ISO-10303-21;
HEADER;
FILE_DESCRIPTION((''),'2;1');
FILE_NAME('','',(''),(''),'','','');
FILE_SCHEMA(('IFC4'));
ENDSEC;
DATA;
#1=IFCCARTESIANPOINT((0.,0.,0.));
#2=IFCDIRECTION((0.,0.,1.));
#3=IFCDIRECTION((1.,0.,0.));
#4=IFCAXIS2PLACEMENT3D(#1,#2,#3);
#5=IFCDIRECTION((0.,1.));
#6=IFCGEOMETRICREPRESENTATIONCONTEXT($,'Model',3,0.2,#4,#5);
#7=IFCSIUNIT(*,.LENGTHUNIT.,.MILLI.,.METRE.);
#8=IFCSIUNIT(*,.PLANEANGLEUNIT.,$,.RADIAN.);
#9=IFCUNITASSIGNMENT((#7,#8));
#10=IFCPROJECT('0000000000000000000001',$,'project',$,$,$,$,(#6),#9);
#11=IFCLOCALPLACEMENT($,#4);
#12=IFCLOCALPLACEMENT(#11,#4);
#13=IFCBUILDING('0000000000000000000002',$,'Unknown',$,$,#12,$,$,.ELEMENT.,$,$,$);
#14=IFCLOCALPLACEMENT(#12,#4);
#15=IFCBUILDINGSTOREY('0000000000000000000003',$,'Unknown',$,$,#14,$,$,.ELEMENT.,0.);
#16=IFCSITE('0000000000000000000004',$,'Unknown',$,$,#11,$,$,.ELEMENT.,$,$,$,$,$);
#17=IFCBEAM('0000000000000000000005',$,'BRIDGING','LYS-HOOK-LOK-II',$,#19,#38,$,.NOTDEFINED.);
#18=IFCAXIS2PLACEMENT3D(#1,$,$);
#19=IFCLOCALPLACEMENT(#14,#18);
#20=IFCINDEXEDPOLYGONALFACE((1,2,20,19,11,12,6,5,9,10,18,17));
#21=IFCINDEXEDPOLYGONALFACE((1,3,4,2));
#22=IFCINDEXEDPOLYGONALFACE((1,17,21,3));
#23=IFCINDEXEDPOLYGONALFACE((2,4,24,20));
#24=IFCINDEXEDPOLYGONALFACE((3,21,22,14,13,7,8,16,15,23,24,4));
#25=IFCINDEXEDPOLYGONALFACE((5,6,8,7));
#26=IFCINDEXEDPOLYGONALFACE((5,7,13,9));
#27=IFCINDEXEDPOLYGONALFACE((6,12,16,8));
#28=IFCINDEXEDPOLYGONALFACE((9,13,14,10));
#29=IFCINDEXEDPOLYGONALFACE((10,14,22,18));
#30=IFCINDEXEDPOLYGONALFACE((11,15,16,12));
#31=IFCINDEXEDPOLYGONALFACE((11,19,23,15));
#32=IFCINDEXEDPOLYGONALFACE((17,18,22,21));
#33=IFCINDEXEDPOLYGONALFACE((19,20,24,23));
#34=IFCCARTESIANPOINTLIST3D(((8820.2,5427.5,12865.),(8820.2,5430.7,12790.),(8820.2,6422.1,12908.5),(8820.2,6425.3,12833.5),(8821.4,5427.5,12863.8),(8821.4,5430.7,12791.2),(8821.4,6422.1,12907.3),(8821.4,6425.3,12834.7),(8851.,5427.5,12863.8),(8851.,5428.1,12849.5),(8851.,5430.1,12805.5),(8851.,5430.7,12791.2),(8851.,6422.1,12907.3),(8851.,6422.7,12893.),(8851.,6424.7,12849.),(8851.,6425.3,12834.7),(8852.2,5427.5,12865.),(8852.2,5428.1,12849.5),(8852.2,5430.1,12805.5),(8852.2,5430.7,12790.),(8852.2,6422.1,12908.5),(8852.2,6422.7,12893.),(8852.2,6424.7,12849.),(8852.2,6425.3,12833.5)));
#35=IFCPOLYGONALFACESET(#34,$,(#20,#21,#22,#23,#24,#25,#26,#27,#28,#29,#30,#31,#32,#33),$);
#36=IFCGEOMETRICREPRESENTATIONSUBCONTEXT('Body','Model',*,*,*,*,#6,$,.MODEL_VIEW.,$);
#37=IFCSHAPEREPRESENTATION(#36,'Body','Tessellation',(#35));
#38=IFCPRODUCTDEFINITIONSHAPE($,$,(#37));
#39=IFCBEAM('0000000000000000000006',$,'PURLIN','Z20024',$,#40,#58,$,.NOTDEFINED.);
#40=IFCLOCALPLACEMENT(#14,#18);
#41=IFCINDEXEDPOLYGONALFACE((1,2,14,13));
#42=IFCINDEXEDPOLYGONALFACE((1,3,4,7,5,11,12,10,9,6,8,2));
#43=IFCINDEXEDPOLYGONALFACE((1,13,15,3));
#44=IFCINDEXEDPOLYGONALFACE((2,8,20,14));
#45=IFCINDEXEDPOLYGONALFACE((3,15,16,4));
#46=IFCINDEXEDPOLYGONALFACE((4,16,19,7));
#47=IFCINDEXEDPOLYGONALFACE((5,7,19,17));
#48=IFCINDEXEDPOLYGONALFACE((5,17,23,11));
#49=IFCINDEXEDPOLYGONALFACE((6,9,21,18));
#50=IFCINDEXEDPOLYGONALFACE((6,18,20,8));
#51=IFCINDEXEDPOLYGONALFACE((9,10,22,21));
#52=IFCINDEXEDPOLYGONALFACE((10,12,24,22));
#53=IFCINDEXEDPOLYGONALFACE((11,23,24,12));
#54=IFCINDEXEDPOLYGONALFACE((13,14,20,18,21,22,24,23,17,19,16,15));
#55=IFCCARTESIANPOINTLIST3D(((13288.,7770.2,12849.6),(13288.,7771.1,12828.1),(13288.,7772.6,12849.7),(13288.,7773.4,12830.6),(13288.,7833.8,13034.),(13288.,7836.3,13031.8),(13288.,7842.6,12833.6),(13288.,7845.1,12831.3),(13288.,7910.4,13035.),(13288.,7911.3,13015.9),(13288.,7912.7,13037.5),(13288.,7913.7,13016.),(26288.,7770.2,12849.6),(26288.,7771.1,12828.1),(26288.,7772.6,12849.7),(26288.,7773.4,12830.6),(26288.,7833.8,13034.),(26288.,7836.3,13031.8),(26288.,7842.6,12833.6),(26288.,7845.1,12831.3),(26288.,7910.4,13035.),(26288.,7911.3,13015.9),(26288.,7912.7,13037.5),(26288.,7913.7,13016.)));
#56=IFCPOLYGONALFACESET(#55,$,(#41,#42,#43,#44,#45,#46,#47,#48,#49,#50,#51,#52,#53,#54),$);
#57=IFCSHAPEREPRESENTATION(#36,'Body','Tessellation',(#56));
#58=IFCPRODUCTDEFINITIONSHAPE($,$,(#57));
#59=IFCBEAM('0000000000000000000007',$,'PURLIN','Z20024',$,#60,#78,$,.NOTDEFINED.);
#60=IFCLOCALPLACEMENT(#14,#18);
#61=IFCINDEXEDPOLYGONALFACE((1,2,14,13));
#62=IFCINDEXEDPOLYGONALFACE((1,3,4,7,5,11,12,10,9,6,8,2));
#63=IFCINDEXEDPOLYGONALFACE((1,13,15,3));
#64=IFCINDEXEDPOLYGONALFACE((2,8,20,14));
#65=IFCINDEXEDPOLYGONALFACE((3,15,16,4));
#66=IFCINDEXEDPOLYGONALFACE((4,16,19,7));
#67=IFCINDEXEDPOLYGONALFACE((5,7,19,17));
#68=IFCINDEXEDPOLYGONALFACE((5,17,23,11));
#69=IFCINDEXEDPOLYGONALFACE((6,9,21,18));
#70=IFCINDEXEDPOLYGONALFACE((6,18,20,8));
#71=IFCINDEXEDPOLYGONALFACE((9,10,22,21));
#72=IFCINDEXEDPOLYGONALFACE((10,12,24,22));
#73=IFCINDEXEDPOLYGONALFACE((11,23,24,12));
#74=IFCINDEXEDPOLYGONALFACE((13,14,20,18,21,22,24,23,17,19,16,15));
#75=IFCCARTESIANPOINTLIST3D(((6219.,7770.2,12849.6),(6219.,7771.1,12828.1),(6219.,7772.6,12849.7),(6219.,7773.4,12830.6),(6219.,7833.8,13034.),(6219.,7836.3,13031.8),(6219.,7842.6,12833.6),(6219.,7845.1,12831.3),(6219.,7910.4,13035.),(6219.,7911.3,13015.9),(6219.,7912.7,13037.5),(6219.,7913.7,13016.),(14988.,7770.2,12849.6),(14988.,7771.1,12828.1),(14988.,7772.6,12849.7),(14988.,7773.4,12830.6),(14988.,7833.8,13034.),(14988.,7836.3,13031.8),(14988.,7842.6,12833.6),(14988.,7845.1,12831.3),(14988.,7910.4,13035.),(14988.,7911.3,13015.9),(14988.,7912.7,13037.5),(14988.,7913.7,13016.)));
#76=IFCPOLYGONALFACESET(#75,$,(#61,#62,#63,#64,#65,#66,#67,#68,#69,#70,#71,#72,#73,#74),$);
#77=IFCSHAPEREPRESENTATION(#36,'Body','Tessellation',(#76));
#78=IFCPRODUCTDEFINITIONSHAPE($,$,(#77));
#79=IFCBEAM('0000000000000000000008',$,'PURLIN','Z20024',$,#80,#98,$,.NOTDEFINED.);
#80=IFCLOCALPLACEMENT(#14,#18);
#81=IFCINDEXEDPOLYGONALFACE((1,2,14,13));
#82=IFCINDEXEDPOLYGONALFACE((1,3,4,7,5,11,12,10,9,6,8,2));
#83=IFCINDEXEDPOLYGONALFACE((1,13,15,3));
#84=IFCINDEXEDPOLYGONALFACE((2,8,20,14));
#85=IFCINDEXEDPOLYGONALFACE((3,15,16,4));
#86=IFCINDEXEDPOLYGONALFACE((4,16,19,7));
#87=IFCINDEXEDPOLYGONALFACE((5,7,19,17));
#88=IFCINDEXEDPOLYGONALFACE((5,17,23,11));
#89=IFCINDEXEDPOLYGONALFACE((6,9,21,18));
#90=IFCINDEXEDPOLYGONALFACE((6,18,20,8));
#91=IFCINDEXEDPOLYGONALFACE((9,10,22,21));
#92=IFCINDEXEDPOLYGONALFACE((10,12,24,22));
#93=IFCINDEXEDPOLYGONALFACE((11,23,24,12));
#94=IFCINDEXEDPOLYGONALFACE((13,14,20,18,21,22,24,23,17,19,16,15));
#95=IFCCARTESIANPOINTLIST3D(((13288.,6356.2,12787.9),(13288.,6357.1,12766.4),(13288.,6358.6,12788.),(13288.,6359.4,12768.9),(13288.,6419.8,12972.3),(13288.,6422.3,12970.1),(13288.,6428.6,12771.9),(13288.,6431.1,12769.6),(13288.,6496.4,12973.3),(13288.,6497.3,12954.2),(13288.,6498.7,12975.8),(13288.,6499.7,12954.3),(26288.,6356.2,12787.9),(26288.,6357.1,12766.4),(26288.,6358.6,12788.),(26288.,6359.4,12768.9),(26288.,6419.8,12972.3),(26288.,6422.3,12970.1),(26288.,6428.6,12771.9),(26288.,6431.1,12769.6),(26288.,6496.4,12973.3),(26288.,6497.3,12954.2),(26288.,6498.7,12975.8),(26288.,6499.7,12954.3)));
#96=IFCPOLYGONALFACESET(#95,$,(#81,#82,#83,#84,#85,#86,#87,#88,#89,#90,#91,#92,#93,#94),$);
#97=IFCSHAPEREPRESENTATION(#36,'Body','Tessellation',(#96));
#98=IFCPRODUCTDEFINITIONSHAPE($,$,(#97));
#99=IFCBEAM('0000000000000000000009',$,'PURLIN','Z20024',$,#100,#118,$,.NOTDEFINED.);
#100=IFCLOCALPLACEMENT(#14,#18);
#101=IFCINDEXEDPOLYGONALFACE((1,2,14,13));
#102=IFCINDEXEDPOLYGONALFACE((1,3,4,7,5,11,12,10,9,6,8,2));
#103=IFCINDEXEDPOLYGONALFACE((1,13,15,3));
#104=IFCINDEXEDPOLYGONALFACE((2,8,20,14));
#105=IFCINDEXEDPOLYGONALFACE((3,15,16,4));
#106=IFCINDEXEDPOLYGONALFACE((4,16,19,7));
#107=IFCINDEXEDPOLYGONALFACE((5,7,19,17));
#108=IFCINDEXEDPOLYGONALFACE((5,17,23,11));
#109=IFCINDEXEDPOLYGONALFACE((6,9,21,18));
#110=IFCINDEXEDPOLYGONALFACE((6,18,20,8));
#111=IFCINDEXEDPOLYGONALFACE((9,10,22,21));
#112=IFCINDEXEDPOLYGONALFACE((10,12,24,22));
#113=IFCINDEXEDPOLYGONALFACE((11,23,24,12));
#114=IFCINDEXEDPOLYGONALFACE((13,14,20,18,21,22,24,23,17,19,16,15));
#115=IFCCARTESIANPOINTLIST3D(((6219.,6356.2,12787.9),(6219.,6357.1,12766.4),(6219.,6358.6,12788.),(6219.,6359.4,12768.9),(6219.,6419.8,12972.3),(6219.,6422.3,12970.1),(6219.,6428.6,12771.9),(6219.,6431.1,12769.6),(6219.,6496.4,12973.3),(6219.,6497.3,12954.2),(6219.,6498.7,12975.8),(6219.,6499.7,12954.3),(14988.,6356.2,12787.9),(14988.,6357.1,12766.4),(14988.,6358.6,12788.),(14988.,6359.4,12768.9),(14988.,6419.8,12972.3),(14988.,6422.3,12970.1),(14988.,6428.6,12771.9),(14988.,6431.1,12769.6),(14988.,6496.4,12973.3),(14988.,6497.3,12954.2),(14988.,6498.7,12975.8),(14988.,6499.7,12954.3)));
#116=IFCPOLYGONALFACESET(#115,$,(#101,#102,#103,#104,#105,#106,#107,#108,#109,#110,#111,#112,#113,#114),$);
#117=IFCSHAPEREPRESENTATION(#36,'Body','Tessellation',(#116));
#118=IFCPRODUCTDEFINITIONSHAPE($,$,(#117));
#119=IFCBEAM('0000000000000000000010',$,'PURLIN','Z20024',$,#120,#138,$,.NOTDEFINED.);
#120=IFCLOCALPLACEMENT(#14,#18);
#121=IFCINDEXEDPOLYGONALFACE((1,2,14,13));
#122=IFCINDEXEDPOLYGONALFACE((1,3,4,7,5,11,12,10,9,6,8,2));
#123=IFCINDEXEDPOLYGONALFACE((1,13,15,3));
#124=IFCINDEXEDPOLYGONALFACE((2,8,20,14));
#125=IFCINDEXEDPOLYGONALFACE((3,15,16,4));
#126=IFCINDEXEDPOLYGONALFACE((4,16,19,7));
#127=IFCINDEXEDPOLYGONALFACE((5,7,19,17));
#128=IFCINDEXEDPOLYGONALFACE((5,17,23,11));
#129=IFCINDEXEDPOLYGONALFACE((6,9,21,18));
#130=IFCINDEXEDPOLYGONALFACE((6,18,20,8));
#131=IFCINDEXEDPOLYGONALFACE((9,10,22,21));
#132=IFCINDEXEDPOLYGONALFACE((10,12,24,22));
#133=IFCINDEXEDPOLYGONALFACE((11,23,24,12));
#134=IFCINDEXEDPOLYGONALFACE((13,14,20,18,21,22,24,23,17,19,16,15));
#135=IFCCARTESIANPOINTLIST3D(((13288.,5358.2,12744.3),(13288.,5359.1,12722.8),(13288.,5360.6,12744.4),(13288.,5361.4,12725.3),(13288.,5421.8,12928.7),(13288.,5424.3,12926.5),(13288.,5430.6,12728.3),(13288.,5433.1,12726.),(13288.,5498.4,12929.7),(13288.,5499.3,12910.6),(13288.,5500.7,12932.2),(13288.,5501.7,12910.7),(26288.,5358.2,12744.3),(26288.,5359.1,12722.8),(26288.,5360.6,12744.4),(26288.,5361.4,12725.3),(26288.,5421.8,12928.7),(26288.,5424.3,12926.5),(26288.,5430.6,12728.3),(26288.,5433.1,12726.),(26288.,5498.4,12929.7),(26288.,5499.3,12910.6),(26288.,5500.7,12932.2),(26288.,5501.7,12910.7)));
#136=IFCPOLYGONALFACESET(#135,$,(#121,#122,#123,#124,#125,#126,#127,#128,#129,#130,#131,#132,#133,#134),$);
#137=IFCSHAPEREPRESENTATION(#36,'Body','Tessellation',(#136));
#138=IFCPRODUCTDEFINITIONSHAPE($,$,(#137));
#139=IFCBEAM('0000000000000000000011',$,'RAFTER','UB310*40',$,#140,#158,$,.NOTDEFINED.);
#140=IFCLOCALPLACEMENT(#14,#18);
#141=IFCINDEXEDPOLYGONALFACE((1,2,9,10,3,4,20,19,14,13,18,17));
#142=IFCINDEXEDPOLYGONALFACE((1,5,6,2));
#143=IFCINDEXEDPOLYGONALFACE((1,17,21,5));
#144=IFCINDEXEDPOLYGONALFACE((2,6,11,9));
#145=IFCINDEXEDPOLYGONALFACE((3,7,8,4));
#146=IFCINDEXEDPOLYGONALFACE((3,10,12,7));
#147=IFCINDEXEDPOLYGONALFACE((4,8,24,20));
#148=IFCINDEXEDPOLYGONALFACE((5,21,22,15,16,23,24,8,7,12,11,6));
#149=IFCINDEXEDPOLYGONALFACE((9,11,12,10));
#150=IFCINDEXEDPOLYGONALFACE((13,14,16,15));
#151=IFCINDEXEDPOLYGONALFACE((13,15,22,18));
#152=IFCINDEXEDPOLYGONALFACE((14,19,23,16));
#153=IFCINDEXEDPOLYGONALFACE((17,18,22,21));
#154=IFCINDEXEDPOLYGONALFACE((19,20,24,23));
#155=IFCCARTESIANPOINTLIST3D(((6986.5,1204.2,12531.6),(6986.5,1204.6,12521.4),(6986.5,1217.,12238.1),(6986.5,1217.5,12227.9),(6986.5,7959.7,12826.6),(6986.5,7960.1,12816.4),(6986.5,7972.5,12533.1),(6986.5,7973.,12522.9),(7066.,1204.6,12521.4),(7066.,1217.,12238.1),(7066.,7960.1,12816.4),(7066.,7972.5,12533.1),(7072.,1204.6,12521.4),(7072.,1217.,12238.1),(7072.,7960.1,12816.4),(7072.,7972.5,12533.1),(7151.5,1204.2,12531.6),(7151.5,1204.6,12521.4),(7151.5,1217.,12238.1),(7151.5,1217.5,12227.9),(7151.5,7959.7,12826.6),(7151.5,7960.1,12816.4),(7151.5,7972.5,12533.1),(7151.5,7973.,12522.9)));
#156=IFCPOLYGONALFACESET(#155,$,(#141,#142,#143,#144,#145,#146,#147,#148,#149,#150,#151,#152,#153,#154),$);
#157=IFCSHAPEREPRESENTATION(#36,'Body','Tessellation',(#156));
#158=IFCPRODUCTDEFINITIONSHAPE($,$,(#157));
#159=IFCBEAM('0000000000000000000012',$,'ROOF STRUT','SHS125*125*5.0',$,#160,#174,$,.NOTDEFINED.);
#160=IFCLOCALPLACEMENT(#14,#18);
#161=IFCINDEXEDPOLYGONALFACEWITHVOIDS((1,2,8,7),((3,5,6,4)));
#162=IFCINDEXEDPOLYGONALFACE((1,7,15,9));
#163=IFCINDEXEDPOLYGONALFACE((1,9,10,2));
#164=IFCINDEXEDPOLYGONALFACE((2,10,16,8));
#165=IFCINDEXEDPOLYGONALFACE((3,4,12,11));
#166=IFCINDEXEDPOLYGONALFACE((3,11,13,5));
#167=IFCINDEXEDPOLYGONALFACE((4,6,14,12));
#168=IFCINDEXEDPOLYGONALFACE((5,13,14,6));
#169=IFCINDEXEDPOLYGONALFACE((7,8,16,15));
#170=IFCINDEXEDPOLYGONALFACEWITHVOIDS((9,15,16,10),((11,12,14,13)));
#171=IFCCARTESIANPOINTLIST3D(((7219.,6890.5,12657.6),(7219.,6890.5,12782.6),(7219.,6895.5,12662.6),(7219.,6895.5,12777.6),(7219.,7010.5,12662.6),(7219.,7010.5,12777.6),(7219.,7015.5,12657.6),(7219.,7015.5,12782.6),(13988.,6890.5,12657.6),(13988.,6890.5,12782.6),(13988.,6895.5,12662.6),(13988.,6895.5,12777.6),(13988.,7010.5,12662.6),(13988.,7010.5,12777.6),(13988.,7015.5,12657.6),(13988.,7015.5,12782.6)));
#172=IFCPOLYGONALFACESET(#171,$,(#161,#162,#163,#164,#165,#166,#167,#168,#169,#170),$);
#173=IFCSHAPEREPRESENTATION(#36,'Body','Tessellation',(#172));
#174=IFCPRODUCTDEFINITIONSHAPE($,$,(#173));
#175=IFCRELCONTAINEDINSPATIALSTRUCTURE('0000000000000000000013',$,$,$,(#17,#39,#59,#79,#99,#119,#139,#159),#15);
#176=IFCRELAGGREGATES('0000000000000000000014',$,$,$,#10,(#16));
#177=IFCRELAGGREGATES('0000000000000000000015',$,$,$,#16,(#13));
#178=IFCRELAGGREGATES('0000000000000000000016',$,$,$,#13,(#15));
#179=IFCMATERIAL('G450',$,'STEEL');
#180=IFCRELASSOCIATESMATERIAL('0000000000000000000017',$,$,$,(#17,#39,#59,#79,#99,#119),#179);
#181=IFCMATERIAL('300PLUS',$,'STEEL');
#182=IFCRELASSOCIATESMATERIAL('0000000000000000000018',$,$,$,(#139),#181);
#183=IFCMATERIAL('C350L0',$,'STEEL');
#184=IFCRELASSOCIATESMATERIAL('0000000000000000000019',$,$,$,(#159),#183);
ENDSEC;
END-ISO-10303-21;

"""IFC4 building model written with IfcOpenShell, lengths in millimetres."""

from ifc_helpers import new_model, si_unit, direction, frame, origin_with_axes, place, context, subcontext, project, spatial, line, indexed_curve, outline, extrude, material, element, save


model = new_model("IFC4")

# Units and contexts
model_context = context("Model", 3, precision=0.2, world=origin_with_axes(), true_north=direction((0.0, 1.0)))
body_context = subcontext(model_context, "Body", "Model", "MODEL_VIEW")
ifc_project = project(units=[si_unit("LENGTHUNIT", "METRE", prefix="MILLI"), si_unit("PLANEANGLEUNIT", "RADIAN")], contexts=[model_context])

# Site, building, storey
site_placement = place(None, origin_with_axes())
site = spatial("IfcSite", under=ifc_project, at=site_placement, Name="Unknown", CompositionType="ELEMENT")
building_placement = place(site_placement, origin_with_axes())
building = spatial("IfcBuilding", under=site, at=building_placement, Name="Unknown", CompositionType="ELEMENT")
storey_placement = place(building_placement, origin_with_axes())
storey = spatial("IfcBuildingStorey", under=building, at=storey_placement, Name="Unknown", CompositionType="ELEMENT", Elevation=0.0)

# Shared definitions
ifc_material_1 = material(Name="300PLUS", Category="STEEL")

# Beams
ifc_material_2 = material(Name="G450", Category="STEEL")
for number, where, z_axis, x_axis, name in (
    (1, (8836.2, 5429.1, 12827.5), (1.0, 0.0, 0.0), (0.0, 0.999045, 0.043694), "BRIDGING"),
):
    element("IfcBeam", number, at=place(storey_placement, frame(where, z_axis=z_axis, x_axis=x_axis)), inside=storey, material=ifc_material_2, Name=name, Description="LYS-HOOK-LOK-II", PredefinedType="NOTDEFINED", context=body_context, shape_type="SolidModel", body=[
        extrude(outline(indexed_curve([(16.0, -37.5), (16.0, -22.0), (14.8, -22.0), (14.8, -36.3), (-14.8, -36.3), (-14.8, 36.3), (14.8, 36.3), (14.8, 22.0), (16.0, 22.0), (16.0, 37.5), (-16.0, 37.5), (-16.0, -37.5)], segments=[line(1, 2, 3, 4, 5, 6, 7, 8, 9, 10, 11, 12, 1)])), frame((0.0, 0.0, 0.0), z_axis=(-1.0, 0.0, 0.0), x_axis=(0.0, 0.0, 1.0)), (0.0, 0.0, -1.0), 995.6),
    ])
beam_1_placement = place(storey_placement, frame((13288.0, 7839.4, 12932.7), z_axis=(0.0, -0.999048, -0.043619), x_axis=(1.0, 0.0, 0.0)))
element("IfcBeam", 2, at=beam_1_placement, inside=storey, material=ifc_material_2, Name="PURLIN", Description="Z20024", PredefinedType="NOTDEFINED", context=body_context, shape_type="SolidModel", body=[
    extrude(outline(indexed_curve([(72.8, -101.5), (72.8, -80.0), (70.4, -80.0), (70.4, -99.1), (1.2, -99.1), (1.2, 101.5), (-77.8, 101.5), (-77.8, 80.0), (-75.4, 80.0), (-75.4, 99.1), (-1.2, 99.1), (-1.2, -101.5)], segments=[line(1, 2, 3, 4, 5, 6, 7, 8, 9, 10, 11, 12, 1)])), frame((0.0, 0.0, 0.0), z_axis=(-1.0, 0.0, 0.0), x_axis=(0.0, 0.0, 1.0)), (0.0, 0.0, -1.0), 13000.0),
])
beam_2_placement = place(storey_placement, frame((6219.0, 7839.4, 12932.7), z_axis=(0.0, -0.999048, -0.043619), x_axis=(1.0, 0.0, 0.0)))
element("IfcBeam", 3, at=beam_2_placement, inside=storey, material=ifc_material_2, Name="PURLIN", Description="Z20024", PredefinedType="NOTDEFINED", context=body_context, shape_type="SolidModel", body=[
    extrude(outline(indexed_curve([(72.8, -101.5), (72.8, -80.0), (70.4, -80.0), (70.4, -99.1), (1.2, -99.1), (1.2, 101.5), (-77.8, 101.5), (-77.8, 80.0), (-75.4, 80.0), (-75.4, 99.1), (-1.2, 99.1), (-1.2, -101.5)], segments=[line(1, 2, 3, 4, 5, 6, 7, 8, 9, 10, 11, 12, 1)])), frame((0.0, 0.0, 0.0), z_axis=(-1.0, 0.0, 0.0), x_axis=(0.0, 0.0, 1.0)), (0.0, 0.0, -1.0), 8769.0),
])
beam_3_placement = place(storey_placement, frame((13288.0, 6425.4, 12871.0), z_axis=(0.0, -0.999048, -0.043619), x_axis=(1.0, 0.0, 0.0)))
element("IfcBeam", 4, at=beam_3_placement, inside=storey, material=ifc_material_2, Name="PURLIN", Description="Z20024", PredefinedType="NOTDEFINED", context=body_context, shape_type="SolidModel", body=[
    extrude(outline(indexed_curve([(72.8, -101.5), (72.8, -80.0), (70.4, -80.0), (70.4, -99.1), (1.2, -99.1), (1.2, 101.5), (-77.8, 101.5), (-77.8, 80.0), (-75.4, 80.0), (-75.4, 99.1), (-1.2, 99.1), (-1.2, -101.5)], segments=[line(1, 2, 3, 4, 5, 6, 7, 8, 9, 10, 11, 12, 1)])), frame((0.0, 0.0, 0.0), z_axis=(-1.0, 0.0, 0.0), x_axis=(0.0, 0.0, 1.0)), (0.0, 0.0, -1.0), 13000.0),
])
beam_4_placement = place(storey_placement, frame((6219.0, 6425.4, 12871.0), z_axis=(0.0, -0.999048, -0.043619), x_axis=(1.0, 0.0, 0.0)))
element("IfcBeam", 5, at=beam_4_placement, inside=storey, material=ifc_material_2, Name="PURLIN", Description="Z20024", PredefinedType="NOTDEFINED", context=body_context, shape_type="SolidModel", body=[
    extrude(outline(indexed_curve([(72.8, -101.5), (72.8, -80.0), (70.4, -80.0), (70.4, -99.1), (1.2, -99.1), (1.2, 101.5), (-77.8, 101.5), (-77.8, 80.0), (-75.4, 80.0), (-75.4, 99.1), (-1.2, 99.1), (-1.2, -101.5)], segments=[line(1, 2, 3, 4, 5, 6, 7, 8, 9, 10, 11, 12, 1)])), frame((0.0, 0.0, 0.0), z_axis=(-1.0, 0.0, 0.0), x_axis=(0.0, 0.0, 1.0)), (0.0, 0.0, -1.0), 8769.0),
])
beam_5_placement = place(storey_placement, frame((13288.0, 5427.4, 12827.4), z_axis=(0.0, -0.999048, -0.043619), x_axis=(1.0, 0.0, 0.0)))
element("IfcBeam", 6, at=beam_5_placement, inside=storey, material=ifc_material_2, Name="PURLIN", Description="Z20024", PredefinedType="NOTDEFINED", context=body_context, shape_type="SolidModel", body=[
    extrude(outline(indexed_curve([(72.8, -101.5), (72.8, -80.0), (70.4, -80.0), (70.4, -99.1), (1.2, -99.1), (1.2, 101.5), (-77.8, 101.5), (-77.8, 80.0), (-75.4, 80.0), (-75.4, 99.1), (-1.2, 99.1), (-1.2, -101.5)], segments=[line(1, 2, 3, 4, 5, 6, 7, 8, 9, 10, 11, 12, 1)])), frame((0.0, 0.0, 0.0), z_axis=(-1.0, 0.0, 0.0), x_axis=(0.0, 0.0, 1.0)), (0.0, 0.0, -1.0), 13000.0),
])
beam_6_placement = place(storey_placement, frame((7069.0, 7966.3, 12674.7), z_axis=(-1.0, 0.0, 0.0), x_axis=(0.0, -0.999048, -0.043627)))
element("IfcBeam", 7, at=beam_6_placement, inside=storey, material=ifc_material_1, Name="RAFTER", Description="UB310*40", PredefinedType="NOTDEFINED", context=body_context, shape_type="SolidModel", body=[
    extrude(outline(indexed_curve([(-82.5, -152.0), (82.5, -152.0), (82.5, -141.8), (3.0, -141.8), (3.0, 141.8), (82.5, 141.8), (82.5, 152.0), (-82.5, 152.0), (-82.5, 141.8), (-3.0, 141.8), (-3.0, -141.8), (-82.5, -141.8)], segments=[line(1, 2, 3, 4, 5, 6, 7, 8, 9, 10, 11, 12, 1)])), frame((0.0, 0.0, 0.0), z_axis=(-1.0, 0.0, 0.0), x_axis=(0.0, 0.0, 1.0)), (0.0, 0.0, -1.0), 6761.9),
])
ifc_material_3 = material(Name="C350L0", Category="STEEL")
beam_7_placement = place(storey_placement, frame((7219.0, 6953.0, 12720.1), z_axis=(0.0, 0.0, 1.0), x_axis=(1.0, 0.0, 0.0)))
element("IfcBeam", 8, at=beam_7_placement, inside=storey, material=ifc_material_3, Name="ROOF STRUT", Description="SHS125*125*5.0", PredefinedType="NOTDEFINED", context=body_context, shape_type="SolidModel", body=[
    extrude(outline(indexed_curve([(-62.5, -62.5), (62.5, -62.5), (62.5, 62.5), (-62.5, 62.5)], segments=[line(1, 2, 3, 4, 1)]), holes=[indexed_curve([(-57.5, -57.5), (-57.5, 57.5), (57.5, 57.5), (57.5, -57.5)], segments=[line(1, 2, 3, 4, 1)])]), frame((0.0, 0.0, 0.0), z_axis=(-1.0, 0.0, 0.0), x_axis=(0.0, 0.0, 1.0)), (0.0, 0.0, -1.0), 6769.0),
])

save(model, "model.ifc")
